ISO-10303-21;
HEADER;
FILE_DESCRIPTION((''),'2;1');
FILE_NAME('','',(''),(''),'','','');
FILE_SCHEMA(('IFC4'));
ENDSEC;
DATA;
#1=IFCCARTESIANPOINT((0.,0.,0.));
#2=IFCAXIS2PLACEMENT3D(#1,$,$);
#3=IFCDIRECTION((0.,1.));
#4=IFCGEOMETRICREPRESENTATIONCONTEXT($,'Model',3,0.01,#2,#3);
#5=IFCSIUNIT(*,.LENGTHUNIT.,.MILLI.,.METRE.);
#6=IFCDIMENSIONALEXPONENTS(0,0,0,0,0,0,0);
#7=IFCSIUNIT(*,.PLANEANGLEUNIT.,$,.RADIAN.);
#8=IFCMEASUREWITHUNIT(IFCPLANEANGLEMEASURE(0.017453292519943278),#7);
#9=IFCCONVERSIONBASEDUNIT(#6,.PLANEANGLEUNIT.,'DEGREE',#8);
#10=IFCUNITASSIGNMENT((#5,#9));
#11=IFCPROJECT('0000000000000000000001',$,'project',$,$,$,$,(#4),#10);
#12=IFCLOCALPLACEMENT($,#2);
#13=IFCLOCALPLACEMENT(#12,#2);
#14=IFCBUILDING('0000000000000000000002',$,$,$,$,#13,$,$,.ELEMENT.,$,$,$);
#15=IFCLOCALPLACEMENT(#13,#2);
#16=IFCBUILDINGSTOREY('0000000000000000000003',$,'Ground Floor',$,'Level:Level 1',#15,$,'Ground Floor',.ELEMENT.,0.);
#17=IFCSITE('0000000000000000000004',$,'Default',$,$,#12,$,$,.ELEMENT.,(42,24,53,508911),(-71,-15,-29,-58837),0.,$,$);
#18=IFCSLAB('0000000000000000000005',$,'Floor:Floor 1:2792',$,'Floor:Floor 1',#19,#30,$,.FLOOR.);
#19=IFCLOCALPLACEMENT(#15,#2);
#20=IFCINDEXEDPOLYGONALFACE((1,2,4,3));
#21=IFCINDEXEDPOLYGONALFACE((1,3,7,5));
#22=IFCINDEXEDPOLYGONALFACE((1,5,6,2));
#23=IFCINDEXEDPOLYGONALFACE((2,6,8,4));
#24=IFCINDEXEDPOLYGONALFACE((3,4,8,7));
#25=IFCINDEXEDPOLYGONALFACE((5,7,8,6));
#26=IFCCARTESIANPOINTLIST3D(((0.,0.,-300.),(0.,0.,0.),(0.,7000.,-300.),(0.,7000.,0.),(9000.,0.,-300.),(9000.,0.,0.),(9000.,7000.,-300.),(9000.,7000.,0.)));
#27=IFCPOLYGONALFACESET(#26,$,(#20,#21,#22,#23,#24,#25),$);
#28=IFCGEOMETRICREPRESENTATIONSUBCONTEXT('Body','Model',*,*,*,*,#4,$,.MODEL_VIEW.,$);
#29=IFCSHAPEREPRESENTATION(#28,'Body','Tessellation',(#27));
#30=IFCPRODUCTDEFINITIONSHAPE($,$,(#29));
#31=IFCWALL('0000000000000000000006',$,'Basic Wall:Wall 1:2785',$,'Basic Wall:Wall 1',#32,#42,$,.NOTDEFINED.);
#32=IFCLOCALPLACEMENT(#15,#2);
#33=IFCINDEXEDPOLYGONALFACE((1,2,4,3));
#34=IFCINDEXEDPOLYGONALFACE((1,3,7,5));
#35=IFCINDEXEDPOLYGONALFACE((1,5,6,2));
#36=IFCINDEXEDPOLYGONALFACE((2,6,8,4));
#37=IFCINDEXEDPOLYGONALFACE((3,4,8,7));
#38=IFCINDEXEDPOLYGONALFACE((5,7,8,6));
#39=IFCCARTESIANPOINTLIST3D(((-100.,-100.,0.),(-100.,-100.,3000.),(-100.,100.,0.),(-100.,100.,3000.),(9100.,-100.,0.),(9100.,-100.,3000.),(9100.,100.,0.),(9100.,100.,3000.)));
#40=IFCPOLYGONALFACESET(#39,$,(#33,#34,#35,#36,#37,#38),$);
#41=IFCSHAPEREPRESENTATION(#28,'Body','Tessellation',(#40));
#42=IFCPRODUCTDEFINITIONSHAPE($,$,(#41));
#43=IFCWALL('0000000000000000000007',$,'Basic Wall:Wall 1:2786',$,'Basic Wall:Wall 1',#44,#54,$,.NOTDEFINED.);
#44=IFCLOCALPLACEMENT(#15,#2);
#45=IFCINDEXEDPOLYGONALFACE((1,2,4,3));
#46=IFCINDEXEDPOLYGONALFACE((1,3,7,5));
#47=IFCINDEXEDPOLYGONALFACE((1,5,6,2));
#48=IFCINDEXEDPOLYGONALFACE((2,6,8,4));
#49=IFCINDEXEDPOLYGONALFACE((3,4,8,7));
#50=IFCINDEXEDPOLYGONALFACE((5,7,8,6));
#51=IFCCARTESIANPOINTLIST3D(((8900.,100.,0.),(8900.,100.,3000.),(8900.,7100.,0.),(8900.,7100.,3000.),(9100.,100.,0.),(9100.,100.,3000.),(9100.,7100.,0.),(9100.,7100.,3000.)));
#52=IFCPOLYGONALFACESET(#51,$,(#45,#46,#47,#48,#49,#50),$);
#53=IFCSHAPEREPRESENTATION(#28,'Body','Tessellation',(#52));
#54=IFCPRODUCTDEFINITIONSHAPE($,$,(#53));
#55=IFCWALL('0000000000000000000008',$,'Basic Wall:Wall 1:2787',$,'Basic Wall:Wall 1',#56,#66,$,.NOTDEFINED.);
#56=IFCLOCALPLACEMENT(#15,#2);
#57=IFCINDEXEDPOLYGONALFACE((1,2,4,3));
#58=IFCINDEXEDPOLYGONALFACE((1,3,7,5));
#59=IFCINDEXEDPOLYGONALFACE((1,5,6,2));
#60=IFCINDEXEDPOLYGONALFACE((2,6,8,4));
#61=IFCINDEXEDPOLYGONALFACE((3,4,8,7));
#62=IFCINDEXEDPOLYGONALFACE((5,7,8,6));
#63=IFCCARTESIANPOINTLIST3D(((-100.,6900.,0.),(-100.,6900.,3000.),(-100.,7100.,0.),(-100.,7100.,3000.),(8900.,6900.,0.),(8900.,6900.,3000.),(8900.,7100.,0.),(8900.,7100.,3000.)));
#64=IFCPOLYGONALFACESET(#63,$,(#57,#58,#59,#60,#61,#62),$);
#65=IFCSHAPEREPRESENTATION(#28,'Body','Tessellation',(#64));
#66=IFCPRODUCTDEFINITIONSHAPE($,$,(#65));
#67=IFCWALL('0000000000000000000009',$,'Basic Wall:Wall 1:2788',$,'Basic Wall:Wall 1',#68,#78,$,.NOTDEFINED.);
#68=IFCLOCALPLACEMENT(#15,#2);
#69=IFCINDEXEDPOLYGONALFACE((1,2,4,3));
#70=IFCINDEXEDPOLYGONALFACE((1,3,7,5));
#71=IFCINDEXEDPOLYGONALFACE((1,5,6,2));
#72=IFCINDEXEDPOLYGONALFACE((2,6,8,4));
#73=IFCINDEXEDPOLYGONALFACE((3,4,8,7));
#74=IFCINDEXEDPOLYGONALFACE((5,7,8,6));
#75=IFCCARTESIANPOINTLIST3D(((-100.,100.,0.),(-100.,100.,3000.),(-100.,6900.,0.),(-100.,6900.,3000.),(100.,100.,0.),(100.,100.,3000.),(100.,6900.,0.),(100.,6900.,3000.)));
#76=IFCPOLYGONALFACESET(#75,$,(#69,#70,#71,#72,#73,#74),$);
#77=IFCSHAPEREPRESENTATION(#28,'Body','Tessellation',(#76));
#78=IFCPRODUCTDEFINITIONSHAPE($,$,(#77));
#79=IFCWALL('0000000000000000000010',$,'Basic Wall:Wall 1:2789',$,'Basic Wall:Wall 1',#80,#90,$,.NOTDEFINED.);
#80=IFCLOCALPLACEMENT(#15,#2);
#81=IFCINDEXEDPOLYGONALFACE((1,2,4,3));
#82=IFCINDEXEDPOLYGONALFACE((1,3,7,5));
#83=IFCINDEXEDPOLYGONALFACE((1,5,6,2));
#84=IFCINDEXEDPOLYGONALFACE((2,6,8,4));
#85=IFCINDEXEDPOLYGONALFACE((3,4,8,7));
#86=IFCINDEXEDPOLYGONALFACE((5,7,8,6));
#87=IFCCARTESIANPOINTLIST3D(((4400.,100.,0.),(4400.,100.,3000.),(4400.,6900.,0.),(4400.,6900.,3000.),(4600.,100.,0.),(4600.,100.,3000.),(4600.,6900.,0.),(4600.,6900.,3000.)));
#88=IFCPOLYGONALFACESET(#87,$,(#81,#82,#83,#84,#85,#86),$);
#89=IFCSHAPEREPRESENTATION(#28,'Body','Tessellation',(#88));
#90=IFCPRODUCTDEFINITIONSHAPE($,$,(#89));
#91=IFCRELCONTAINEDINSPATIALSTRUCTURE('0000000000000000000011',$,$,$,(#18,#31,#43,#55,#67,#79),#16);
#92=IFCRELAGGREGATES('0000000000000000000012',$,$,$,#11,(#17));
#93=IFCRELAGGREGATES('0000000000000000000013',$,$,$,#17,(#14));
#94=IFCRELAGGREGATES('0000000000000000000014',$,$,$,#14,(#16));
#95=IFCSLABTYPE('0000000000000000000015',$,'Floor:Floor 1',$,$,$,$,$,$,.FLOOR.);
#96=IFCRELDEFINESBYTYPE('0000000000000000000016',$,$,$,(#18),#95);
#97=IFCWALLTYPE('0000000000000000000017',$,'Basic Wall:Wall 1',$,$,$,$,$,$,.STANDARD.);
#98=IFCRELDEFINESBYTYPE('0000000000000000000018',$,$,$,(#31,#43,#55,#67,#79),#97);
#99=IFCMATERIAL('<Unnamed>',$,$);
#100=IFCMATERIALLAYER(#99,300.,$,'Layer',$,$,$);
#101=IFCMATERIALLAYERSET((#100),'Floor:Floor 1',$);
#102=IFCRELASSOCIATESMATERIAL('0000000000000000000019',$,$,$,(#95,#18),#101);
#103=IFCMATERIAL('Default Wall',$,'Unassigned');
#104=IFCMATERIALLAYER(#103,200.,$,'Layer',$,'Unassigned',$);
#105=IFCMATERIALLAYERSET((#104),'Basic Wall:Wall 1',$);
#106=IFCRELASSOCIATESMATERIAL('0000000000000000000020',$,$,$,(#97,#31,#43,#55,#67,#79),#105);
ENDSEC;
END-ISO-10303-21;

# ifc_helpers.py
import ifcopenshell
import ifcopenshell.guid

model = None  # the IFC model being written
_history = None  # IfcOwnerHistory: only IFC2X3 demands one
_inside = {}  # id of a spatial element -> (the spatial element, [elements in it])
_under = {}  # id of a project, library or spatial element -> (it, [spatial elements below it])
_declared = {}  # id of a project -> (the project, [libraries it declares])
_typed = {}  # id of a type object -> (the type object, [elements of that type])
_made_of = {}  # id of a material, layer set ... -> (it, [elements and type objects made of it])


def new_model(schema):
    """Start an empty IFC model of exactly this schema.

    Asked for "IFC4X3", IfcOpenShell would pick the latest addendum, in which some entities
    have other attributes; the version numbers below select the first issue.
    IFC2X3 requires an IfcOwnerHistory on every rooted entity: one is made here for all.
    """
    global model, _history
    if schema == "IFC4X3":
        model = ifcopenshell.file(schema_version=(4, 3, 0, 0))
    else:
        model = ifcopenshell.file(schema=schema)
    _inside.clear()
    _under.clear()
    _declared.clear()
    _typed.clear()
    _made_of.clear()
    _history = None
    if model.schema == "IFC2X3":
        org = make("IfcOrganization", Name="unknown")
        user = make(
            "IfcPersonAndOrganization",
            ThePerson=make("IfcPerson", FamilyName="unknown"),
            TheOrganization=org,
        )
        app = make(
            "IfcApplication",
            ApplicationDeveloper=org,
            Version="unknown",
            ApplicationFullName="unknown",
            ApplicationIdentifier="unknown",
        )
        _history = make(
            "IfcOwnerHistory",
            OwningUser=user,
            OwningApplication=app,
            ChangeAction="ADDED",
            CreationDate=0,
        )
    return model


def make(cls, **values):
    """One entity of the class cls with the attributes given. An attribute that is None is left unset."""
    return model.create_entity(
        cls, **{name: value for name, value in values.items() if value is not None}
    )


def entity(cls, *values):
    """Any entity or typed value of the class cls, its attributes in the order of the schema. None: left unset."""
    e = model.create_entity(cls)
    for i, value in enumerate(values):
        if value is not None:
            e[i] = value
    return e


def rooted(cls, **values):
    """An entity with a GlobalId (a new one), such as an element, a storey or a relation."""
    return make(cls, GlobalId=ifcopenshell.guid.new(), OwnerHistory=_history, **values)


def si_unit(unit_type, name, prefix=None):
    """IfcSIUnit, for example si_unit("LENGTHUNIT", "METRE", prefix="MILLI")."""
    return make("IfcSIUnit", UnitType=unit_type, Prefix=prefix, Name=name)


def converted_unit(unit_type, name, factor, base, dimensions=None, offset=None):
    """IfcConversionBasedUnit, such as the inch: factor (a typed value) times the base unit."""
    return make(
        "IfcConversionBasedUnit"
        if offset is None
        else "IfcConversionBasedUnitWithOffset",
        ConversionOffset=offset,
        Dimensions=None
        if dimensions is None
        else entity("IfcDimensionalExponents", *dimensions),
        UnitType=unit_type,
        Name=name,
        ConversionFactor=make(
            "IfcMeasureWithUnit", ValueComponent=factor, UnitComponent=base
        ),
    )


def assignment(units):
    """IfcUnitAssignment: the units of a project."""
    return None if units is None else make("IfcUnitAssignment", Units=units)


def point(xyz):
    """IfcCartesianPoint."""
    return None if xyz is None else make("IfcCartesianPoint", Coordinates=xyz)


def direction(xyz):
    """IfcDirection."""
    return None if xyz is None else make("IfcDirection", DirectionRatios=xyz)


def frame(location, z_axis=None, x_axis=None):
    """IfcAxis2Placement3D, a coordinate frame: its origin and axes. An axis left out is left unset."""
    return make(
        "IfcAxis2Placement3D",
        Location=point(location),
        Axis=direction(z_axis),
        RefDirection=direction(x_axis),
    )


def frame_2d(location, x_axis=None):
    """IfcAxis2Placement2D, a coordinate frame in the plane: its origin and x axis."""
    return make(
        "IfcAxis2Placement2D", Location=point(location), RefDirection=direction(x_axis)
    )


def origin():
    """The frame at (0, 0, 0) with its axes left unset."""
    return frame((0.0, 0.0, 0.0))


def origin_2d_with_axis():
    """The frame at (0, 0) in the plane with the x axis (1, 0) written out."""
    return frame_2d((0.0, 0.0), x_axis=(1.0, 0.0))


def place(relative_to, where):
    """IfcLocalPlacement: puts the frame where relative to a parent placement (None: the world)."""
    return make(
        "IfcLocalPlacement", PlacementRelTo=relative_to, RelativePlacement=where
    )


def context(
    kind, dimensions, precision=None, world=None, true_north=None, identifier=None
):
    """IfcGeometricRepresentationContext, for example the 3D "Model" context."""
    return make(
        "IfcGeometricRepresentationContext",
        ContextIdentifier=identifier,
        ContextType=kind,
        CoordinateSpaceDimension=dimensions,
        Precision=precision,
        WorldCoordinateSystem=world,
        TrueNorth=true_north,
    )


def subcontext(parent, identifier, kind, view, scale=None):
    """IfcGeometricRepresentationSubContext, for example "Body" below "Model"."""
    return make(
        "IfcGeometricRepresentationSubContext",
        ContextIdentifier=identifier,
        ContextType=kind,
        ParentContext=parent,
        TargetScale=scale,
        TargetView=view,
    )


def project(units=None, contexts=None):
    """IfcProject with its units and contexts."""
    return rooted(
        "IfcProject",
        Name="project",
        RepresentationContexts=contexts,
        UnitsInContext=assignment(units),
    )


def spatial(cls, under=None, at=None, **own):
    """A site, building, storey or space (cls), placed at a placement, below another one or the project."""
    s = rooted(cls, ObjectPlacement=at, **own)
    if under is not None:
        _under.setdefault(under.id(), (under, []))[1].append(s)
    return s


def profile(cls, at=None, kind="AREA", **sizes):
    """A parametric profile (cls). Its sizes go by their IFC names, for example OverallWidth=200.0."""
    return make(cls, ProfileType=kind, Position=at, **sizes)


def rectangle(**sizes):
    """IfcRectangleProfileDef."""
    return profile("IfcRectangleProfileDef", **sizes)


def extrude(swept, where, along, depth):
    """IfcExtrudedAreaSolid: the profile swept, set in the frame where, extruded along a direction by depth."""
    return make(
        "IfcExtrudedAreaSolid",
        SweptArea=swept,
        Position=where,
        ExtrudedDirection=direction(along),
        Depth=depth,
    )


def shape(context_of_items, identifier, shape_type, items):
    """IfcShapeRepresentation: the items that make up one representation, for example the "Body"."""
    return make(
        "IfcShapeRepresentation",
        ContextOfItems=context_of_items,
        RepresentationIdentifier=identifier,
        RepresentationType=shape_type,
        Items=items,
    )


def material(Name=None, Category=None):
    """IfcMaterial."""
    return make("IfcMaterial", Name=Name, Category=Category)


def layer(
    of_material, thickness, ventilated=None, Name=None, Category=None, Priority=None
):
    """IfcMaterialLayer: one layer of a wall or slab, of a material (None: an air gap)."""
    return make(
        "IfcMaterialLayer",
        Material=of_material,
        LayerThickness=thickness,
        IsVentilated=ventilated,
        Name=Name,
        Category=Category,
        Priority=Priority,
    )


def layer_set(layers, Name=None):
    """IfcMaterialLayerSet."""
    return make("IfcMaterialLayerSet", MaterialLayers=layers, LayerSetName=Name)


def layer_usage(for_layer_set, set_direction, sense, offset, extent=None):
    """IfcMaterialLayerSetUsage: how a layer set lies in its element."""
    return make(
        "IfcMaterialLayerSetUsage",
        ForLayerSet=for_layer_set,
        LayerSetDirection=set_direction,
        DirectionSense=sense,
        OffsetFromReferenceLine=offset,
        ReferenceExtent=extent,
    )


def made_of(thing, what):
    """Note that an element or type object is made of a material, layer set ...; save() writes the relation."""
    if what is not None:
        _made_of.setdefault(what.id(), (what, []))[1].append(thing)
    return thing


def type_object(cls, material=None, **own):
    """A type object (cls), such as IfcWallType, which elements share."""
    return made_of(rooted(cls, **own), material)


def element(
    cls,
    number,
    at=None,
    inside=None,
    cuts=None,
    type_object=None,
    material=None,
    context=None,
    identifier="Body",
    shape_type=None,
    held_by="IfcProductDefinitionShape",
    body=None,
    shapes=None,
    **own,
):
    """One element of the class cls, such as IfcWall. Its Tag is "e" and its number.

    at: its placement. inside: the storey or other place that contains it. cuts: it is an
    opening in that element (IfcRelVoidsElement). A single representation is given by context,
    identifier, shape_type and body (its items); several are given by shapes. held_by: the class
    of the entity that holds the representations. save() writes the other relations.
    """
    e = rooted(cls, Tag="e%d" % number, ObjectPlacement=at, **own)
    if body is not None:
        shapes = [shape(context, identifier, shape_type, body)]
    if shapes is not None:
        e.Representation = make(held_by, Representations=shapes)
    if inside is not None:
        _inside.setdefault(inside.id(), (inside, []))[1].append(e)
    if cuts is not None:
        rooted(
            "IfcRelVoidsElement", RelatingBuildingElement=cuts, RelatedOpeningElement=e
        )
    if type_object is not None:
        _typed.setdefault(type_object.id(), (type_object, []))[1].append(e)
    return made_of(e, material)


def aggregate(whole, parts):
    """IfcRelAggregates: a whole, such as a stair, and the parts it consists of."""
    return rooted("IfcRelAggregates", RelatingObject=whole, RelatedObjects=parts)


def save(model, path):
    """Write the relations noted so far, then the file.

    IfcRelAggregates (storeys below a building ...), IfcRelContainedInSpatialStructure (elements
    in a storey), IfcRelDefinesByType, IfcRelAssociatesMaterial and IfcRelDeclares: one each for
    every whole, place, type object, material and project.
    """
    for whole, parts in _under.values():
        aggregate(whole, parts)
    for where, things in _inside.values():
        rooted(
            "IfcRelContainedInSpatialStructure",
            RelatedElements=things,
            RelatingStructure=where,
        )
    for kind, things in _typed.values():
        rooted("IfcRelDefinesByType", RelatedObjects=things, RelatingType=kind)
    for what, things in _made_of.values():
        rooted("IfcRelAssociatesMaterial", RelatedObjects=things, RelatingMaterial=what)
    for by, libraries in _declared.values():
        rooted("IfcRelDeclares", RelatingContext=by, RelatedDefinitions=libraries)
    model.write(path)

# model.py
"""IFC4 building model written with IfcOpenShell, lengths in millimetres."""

from ifc_helpers import new_model, entity, si_unit, converted_unit, direction, frame, frame_2d, origin, origin_2d_with_axis, place, context, subcontext, project, spatial, rectangle, extrude, material, layer, layer_set, layer_usage, type_object, element, save


model = new_model("IFC4")

# Units and contexts
model_context = context("Model", 3, precision=0.01, world=origin(), true_north=direction((0.0, 1.0)))
body_context = subcontext(model_context, "Body", "Model", "MODEL_VIEW")
ifc_project = project(units=[si_unit("LENGTHUNIT", "METRE", prefix="MILLI"), converted_unit("PLANEANGLEUNIT", "DEGREE", entity("IfcPlaneAngleMeasure", 0.017453292519943278), si_unit("PLANEANGLEUNIT", "RADIAN"), dimensions=[0, 0, 0, 0, 0, 0, 0])], contexts=[model_context])

# Site, building, storey
site_placement = place(None, origin())
site = spatial("IfcSite", under=ifc_project, at=site_placement, Name="Default", CompositionType="ELEMENT", RefLatitude=(42, 24, 53, 508911), RefLongitude=(-71, -15, -29, -58837), RefElevation=0.0)
building_placement = place(site_placement, origin())
building = spatial("IfcBuilding", under=site, at=building_placement, CompositionType="ELEMENT")
storey_placement = place(building_placement, origin())
storey = spatial("IfcBuildingStorey", under=building, at=storey_placement, Name="Ground Floor", ObjectType="Level:Level 1", LongName="Ground Floor", CompositionType="ELEMENT", Elevation=0.0)

# Slab
ifc_material_1 = material(Name="<Unnamed>")
ifc_layer_1 = layer(ifc_material_1, 300.0, Name="Layer")
ifc_layer_set_1 = layer_set([ifc_layer_1], Name="Floor:Floor 1")
ifc_layer_usage_1 = layer_usage(ifc_layer_set_1, "AXIS3", "POSITIVE", 0.0)
slab_type = type_object("IfcSlabType", Name="Floor:Floor 1", PredefinedType="FLOOR", material=ifc_layer_set_1)
slab_placement = place(storey_placement, origin())
element("IfcSlab", 1, at=slab_placement, inside=storey, type_object=slab_type, material=ifc_layer_usage_1, Name="Floor:Floor 1:2792", ObjectType="Floor:Floor 1", PredefinedType="FLOOR", context=body_context, shape_type="SweptSolid", body=[
    extrude(rectangle(XDim=7000.0, YDim=9000.0, at=origin_2d_with_axis()), frame((4500.0, 3500.0, 0.0), z_axis=(0.0, 0.0, -1.0), x_axis=(0.0, 1.0, 0.0)), (0.0, 0.0, 1.0), 300.0),
])

# Walls
ifc_material_2 = material(Name="Default Wall", Category="Unassigned")
ifc_layer_2 = layer(ifc_material_2, 200.0, Name="Layer", Category="Unassigned")
ifc_layer_set_2 = layer_set([ifc_layer_2], Name="Basic Wall:Wall 1")
ifc_layer_usage_2 = layer_usage(ifc_layer_set_2, "AXIS2", "NEGATIVE", 100.0)
wall_type = type_object("IfcWallType", Name="Basic Wall:Wall 1", PredefinedType="STANDARD", material=ifc_layer_set_2)
wall_1_placement = place(storey_placement, frame((-100.0, 0.0, 0.0)))
element("IfcWall", 2, at=wall_1_placement, inside=storey, type_object=wall_type, material=ifc_layer_usage_2, Name="Basic Wall:Wall 1:2785", ObjectType="Basic Wall:Wall 1", PredefinedType="NOTDEFINED", context=body_context, shape_type="SweptSolid", body=[
    extrude(rectangle(XDim=9200.0, YDim=200.0, at=frame_2d((4600.0, 0.0), x_axis=(-1.0, 0.0))), origin(), (0.0, 0.0, 1.0), 3000.0),
])
ifc_layer_usage_3 = layer_usage(ifc_layer_set_2, "AXIS2", "NEGATIVE", 100.0)
wall_2_placement = place(storey_placement, frame((9000.0, 100.0, 0.0), z_axis=(0.0, 0.0, 1.0), x_axis=(0.0, 1.0, 0.0)))
element("IfcWall", 3, at=wall_2_placement, inside=storey, type_object=wall_type, material=ifc_layer_usage_3, Name="Basic Wall:Wall 1:2786", ObjectType="Basic Wall:Wall 1", PredefinedType="NOTDEFINED", context=body_context, shape_type="SweptSolid", body=[
    extrude(rectangle(XDim=7000.0, YDim=200.0, at=frame_2d((3500.0, 0.0), x_axis=(-1.0, 0.0))), origin(), (0.0, 0.0, 1.0), 3000.0),
])
ifc_layer_usage_4 = layer_usage(ifc_layer_set_2, "AXIS2", "NEGATIVE", 100.0)
wall_3_placement = place(storey_placement, frame((8900.0, 7000.0, 0.0), z_axis=(0.0, 0.0, 1.0), x_axis=(-1.0, 0.0, 0.0)))
element("IfcWall", 4, at=wall_3_placement, inside=storey, type_object=wall_type, material=ifc_layer_usage_4, Name="Basic Wall:Wall 1:2787", ObjectType="Basic Wall:Wall 1", PredefinedType="NOTDEFINED", context=body_context, shape_type="SweptSolid", body=[
    extrude(rectangle(XDim=9000.0, YDim=200.0, at=frame_2d((4500.0, 0.0), x_axis=(-1.0, 0.0))), origin(), (0.0, 0.0, 1.0), 3000.0),
])
ifc_layer_usage_5 = layer_usage(ifc_layer_set_2, "AXIS2", "NEGATIVE", 100.0)
wall_4_placement = place(storey_placement, frame((0.0, 6900.0, 0.0), z_axis=(0.0, 0.0, 1.0), x_axis=(0.0, -1.0, 0.0)))
element("IfcWall", 5, at=wall_4_placement, inside=storey, type_object=wall_type, material=ifc_layer_usage_5, Name="Basic Wall:Wall 1:2788", ObjectType="Basic Wall:Wall 1", PredefinedType="NOTDEFINED", context=body_context, shape_type="SweptSolid", body=[
    extrude(rectangle(XDim=6800.0, YDim=200.0, at=frame_2d((3400.0, 0.0), x_axis=(-1.0, 0.0))), origin(), (0.0, 0.0, 1.0), 3000.0),
])
ifc_layer_usage_6 = layer_usage(ifc_layer_set_2, "AXIS2", "NEGATIVE", 100.0)
wall_5_placement = place(storey_placement, frame((4500.0, 100.0, 0.0), z_axis=(0.0, 0.0, 1.0), x_axis=(0.0, 1.0, 0.0)))
element("IfcWall", 6, at=wall_5_placement, inside=storey, type_object=wall_type, material=ifc_layer_usage_6, Name="Basic Wall:Wall 1:2789", ObjectType="Basic Wall:Wall 1", PredefinedType="NOTDEFINED", context=body_context, shape_type="SweptSolid", body=[
    extrude(rectangle(XDim=6800.0, YDim=200.0, at=frame_2d((3400.0, 0.0), x_axis=(-1.0, 0.0))), origin(), (0.0, 0.0, 1.0), 3000.0),
])

save(model, "model.ifc")
